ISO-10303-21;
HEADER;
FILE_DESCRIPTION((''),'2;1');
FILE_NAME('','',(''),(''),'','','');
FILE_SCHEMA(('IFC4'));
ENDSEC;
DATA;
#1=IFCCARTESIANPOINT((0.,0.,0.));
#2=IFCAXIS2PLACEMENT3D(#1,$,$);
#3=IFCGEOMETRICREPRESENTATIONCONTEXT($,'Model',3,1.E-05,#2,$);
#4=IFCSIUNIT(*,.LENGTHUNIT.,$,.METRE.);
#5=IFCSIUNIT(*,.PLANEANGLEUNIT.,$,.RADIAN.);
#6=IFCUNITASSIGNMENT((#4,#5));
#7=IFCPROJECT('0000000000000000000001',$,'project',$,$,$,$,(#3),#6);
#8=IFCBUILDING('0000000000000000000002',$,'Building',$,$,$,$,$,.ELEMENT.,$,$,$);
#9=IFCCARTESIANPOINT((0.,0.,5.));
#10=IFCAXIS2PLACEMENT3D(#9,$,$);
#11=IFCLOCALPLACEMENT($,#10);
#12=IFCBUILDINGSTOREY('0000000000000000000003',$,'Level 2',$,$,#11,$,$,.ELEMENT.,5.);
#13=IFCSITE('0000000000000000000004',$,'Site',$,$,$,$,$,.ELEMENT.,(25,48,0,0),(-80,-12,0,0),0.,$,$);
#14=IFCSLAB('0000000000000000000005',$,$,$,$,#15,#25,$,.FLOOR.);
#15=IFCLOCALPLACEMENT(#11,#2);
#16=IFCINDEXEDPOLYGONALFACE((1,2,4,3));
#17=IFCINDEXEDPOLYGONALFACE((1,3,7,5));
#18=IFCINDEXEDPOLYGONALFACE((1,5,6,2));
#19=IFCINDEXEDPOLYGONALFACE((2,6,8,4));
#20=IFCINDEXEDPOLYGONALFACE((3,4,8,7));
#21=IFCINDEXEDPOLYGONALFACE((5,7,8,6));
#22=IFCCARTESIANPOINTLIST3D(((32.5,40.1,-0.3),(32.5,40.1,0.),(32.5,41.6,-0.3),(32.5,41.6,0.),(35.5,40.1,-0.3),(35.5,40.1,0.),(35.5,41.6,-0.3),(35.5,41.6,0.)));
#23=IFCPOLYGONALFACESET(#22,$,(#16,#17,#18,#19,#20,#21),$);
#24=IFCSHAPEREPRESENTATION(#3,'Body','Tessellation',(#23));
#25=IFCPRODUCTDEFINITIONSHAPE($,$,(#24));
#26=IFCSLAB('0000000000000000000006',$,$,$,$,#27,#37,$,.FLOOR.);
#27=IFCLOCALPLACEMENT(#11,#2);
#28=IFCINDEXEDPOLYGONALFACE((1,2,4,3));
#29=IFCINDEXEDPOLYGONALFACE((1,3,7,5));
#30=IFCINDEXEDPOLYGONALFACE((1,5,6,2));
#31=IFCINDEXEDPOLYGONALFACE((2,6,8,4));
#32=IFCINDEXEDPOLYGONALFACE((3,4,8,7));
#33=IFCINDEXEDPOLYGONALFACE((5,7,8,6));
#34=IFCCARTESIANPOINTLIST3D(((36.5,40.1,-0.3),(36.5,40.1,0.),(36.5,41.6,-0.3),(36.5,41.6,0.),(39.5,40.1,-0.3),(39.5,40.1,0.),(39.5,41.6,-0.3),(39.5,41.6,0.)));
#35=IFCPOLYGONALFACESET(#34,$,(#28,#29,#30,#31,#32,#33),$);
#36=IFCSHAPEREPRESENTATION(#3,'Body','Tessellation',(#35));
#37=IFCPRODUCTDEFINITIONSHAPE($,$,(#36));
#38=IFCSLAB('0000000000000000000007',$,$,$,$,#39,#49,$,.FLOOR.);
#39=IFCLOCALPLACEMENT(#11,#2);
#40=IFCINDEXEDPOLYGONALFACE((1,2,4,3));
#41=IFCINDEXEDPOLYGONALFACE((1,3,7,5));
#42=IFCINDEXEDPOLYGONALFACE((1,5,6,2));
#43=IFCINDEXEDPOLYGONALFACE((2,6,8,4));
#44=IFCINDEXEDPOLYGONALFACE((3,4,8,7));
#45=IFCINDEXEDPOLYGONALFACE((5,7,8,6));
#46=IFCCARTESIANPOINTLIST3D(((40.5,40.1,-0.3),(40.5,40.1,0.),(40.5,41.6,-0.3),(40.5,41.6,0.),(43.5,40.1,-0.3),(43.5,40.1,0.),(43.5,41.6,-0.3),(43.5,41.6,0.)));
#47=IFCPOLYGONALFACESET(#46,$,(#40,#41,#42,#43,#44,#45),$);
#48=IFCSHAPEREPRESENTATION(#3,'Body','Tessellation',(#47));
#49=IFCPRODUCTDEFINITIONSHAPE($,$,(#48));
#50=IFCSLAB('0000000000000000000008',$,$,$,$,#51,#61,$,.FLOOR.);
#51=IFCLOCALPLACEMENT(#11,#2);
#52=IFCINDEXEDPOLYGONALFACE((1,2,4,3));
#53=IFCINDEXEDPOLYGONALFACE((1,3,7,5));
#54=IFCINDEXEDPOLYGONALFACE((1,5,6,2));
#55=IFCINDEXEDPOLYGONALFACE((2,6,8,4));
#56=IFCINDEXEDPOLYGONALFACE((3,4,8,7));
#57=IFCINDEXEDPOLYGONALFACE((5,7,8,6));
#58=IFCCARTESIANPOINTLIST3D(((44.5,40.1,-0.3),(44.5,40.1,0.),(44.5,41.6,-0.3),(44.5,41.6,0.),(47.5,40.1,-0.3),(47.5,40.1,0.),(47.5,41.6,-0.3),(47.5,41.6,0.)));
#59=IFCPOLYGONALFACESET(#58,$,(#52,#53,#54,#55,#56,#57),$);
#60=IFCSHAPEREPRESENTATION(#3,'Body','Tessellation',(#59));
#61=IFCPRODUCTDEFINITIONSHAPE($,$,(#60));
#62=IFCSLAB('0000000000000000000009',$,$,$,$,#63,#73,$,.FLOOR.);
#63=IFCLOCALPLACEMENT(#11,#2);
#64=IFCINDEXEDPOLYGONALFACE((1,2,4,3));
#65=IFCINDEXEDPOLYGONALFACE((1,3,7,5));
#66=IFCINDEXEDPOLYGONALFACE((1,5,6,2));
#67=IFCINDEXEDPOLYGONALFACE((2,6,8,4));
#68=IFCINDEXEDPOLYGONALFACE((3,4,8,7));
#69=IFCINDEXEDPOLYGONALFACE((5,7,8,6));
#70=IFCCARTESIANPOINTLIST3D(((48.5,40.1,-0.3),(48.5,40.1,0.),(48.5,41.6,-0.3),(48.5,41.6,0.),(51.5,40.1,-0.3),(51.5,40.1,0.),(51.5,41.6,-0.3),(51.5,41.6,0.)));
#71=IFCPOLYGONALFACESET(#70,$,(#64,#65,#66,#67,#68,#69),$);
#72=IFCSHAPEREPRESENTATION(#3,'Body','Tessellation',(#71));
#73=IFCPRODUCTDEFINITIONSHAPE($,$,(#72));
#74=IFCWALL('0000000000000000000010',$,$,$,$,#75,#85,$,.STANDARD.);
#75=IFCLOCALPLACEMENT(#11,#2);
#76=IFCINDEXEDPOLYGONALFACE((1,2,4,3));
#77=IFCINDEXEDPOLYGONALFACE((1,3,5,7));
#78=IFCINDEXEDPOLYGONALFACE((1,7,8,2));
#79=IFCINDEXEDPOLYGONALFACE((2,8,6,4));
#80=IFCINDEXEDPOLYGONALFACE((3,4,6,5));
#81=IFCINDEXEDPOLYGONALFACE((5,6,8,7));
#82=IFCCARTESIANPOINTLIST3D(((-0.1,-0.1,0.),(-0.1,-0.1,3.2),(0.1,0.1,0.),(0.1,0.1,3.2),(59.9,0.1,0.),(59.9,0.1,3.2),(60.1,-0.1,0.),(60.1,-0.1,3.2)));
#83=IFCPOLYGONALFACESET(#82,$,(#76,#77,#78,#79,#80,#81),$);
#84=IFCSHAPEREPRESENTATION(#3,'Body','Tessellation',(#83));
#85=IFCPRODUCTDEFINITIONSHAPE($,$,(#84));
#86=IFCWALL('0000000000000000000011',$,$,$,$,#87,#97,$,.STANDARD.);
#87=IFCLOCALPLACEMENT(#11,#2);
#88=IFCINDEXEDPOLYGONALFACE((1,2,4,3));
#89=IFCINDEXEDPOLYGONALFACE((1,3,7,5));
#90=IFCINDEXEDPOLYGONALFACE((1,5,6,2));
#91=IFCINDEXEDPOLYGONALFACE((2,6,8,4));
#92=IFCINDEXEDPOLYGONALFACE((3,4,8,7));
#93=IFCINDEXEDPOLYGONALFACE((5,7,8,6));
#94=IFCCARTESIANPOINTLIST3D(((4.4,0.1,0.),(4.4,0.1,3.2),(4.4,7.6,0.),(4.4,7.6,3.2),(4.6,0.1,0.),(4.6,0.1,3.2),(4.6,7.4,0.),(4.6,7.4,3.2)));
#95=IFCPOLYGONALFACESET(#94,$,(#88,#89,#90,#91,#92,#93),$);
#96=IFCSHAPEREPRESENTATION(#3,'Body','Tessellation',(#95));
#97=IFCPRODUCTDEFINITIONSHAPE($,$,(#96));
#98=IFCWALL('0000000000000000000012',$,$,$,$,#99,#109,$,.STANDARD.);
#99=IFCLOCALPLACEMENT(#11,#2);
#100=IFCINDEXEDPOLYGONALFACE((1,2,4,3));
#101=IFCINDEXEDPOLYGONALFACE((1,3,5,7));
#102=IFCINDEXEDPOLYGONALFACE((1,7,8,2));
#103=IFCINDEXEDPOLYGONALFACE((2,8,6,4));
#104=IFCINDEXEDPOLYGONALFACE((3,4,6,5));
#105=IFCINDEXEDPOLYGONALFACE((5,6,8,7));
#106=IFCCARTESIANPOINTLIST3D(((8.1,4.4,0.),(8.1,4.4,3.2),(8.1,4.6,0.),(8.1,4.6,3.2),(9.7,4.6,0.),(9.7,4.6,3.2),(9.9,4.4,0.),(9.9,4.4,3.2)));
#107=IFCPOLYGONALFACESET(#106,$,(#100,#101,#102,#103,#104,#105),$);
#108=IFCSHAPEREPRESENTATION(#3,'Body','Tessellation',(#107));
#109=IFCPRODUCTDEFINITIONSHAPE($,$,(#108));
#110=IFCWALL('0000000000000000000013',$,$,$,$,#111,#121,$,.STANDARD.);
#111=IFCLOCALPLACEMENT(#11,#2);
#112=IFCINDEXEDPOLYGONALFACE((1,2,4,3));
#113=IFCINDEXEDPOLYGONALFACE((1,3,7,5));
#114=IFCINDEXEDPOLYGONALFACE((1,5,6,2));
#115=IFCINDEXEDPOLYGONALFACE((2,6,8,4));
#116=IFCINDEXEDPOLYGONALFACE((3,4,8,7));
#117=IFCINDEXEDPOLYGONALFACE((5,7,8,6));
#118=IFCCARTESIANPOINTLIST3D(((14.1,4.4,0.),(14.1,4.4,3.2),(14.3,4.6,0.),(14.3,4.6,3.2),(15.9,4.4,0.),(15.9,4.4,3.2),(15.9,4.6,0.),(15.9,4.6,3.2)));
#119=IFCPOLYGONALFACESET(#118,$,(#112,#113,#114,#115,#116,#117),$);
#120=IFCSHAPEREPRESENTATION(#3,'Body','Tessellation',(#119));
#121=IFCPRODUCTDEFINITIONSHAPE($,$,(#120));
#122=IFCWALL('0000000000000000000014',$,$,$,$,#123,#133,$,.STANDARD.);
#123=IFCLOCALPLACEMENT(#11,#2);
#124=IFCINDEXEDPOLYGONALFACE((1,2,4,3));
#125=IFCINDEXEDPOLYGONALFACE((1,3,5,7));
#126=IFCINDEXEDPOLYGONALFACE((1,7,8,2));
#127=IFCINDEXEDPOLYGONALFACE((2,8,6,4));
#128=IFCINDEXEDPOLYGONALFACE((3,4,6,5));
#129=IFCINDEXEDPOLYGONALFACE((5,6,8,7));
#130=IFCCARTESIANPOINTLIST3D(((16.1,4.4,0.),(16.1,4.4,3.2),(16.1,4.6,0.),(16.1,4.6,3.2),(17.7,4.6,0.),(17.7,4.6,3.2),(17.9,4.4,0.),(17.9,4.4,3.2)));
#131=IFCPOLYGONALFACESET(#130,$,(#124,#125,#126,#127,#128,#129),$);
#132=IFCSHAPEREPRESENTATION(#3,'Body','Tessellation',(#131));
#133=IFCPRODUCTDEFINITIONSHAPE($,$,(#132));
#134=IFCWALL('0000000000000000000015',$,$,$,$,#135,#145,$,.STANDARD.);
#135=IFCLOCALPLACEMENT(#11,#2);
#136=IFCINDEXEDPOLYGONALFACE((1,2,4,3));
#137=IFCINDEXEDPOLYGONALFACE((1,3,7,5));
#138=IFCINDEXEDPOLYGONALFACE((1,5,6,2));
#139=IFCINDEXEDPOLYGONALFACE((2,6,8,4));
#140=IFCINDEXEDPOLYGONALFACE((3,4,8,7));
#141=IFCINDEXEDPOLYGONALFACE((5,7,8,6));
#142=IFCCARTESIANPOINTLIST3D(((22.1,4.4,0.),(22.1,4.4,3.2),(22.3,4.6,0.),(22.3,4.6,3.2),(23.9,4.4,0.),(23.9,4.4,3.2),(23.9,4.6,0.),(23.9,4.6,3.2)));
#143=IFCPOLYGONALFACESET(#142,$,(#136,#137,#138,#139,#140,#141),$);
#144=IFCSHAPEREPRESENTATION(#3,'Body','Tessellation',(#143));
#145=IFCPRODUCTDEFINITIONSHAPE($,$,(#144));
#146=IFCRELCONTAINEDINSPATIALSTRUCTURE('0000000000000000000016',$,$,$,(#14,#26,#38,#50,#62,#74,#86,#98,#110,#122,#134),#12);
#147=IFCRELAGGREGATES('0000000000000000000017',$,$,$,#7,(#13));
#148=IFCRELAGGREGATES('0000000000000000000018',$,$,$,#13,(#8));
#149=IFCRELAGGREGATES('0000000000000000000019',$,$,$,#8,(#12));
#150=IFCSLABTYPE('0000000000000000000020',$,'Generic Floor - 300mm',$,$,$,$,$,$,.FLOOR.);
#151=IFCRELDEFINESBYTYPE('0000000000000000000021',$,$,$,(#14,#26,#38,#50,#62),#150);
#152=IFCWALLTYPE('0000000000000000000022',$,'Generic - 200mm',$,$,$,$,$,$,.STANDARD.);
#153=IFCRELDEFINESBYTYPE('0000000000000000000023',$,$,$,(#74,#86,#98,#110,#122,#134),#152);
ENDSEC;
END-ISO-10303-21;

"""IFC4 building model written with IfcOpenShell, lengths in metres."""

from ifc_helpers import new_model, si_unit, frame, origin, place, context, project, spatial, polyline, outline, extrude, type_object, element, save


model = new_model("IFC4")

# Units and contexts
model_context = context("Model", 3, precision=1e-05, world=origin())
ifc_project = project(units=[si_unit("LENGTHUNIT", "METRE"), si_unit("PLANEANGLEUNIT", "RADIAN")], contexts=[model_context])

# Site, building, storey
site = spatial("IfcSite", under=ifc_project, Name="Site", CompositionType="ELEMENT", RefLatitude=(25, 48, 0, 0), RefLongitude=(-80, -12, 0, 0), RefElevation=0.0)
building = spatial("IfcBuilding", under=site, Name="Building", CompositionType="ELEMENT")
storey_placement = place(None, frame((0.0, 0.0, 5.0)))
storey = spatial("IfcBuildingStorey", under=building, at=storey_placement, Name="Level 2", CompositionType="ELEMENT", Elevation=5.0)

# Slabs
slab_type = type_object("IfcSlabType", Name="Generic Floor - 300mm", PredefinedType="FLOOR")
slab_1_placement = place(None, frame((0.0, 0.0, 5.0)))
element("IfcSlab", 1, at=slab_1_placement, inside=storey, type_object=slab_type, PredefinedType="FLOOR", context=model_context, shape_type="SweptSolid", body=[
    extrude(outline(polyline([(32.5, 40.1), (35.5, 40.1), (35.5, 41.6), (32.5, 41.6), (32.5, 40.1)])), origin(), (0.0, 0.0, -1.0), 0.3),
])
slab_2_placement = place(None, frame((0.0, 0.0, 5.0)))
element("IfcSlab", 2, at=slab_2_placement, inside=storey, type_object=slab_type, PredefinedType="FLOOR", context=model_context, shape_type="SweptSolid", body=[
    extrude(outline(polyline([(39.5, 40.1), (39.5, 41.6), (36.5, 41.6), (36.5, 40.1), (39.5, 40.1)])), origin(), (0.0, 0.0, -1.0), 0.3),
])
slab_3_placement = place(None, frame((0.0, 0.0, 5.0)))
element("IfcSlab", 3, at=slab_3_placement, inside=storey, type_object=slab_type, PredefinedType="FLOOR", context=model_context, shape_type="SweptSolid", body=[
    extrude(outline(polyline([(40.5, 40.1), (43.5, 40.1), (43.5, 41.6), (40.5, 41.6), (40.5, 40.1)])), origin(), (0.0, 0.0, -1.0), 0.3),
])
slab_4_placement = place(None, frame((0.0, 0.0, 5.0)))
element("IfcSlab", 4, at=slab_4_placement, inside=storey, type_object=slab_type, PredefinedType="FLOOR", context=model_context, shape_type="SweptSolid", body=[
    extrude(outline(polyline([(47.5, 40.1), (47.5, 41.6), (44.5, 41.6), (44.5, 40.1), (47.5, 40.1)])), origin(), (0.0, 0.0, -1.0), 0.3),
])
slab_5_placement = place(None, frame((0.0, 0.0, 5.0)))
element("IfcSlab", 5, at=slab_5_placement, inside=storey, type_object=slab_type, PredefinedType="FLOOR", context=model_context, shape_type="SweptSolid", body=[
    extrude(outline(polyline([(48.5, 40.1), (51.5, 40.1), (51.5, 41.6), (48.5, 41.6), (48.5, 40.1)])), origin(), (0.0, 0.0, -1.0), 0.3),
])

# Walls
wall_type = type_object("IfcWallType", Name="Generic - 200mm", PredefinedType="STANDARD")
wall_1_placement = place(None, frame((0.0, 0.0, 5.0), z_axis=(0.0, 0.0, 1.0), x_axis=(1.0, 0.0, 0.0)))
element("IfcWall", 6, at=wall_1_placement, inside=storey, type_object=wall_type, PredefinedType="STANDARD", context=model_context, shape_type="SweptSolid", body=[
    extrude(outline(polyline([(-0.1, -0.1), (60.1, -0.1), (59.9, 0.1), (0.1, 0.1), (-0.1, -0.1)])), origin(), (0.0, 0.0, 1.0), 3.2),
])
wall_2_placement = place(None, frame((4.5, 7.5, 5.0), z_axis=(0.0, 0.0, 1.0), x_axis=(0.0, -1.0, 0.0)))
element("IfcWall", 7, at=wall_2_placement, inside=storey, type_object=wall_type, PredefinedType="STANDARD", context=model_context, shape_type="SweptSolid", body=[
    extrude(outline(polyline([(-0.1, -0.1), (7.4, -0.1), (7.4, 0.1), (0.1, 0.1), (-0.1, -0.1)])), origin(), (0.0, 0.0, 1.0), 3.2),
])
wall_3_placement = place(None, frame((9.8, 4.5, 5.0), z_axis=(0.0, 0.0, 1.0), x_axis=(-1.0, 0.0, 0.0)))
element("IfcWall", 8, at=wall_3_placement, inside=storey, type_object=wall_type, PredefinedType="STANDARD", context=model_context, shape_type="SweptSolid", body=[
    extrude(outline(polyline([(0.1, -0.1), (1.7, -0.1), (1.7, 0.1), (-0.1, 0.1), (0.1, -0.1)])), origin(), (0.0, 0.0, 1.0), 3.2),
])
wall_4_placement = place(None, frame((14.2, 4.5, 5.0), z_axis=(0.0, 0.0, 1.0), x_axis=(1.0, 0.0, 0.0)))
element("IfcWall", 9, at=wall_4_placement, inside=storey, type_object=wall_type, PredefinedType="STANDARD", context=model_context, shape_type="SweptSolid", body=[
    extrude(outline(polyline([(-0.1, -0.1), (1.7, -0.1), (1.7, 0.1), (0.1, 0.1), (-0.1, -0.1)])), origin(), (0.0, 0.0, 1.0), 3.2),
])
wall_5_placement = place(None, frame((17.8, 4.5, 5.0), z_axis=(0.0, 0.0, 1.0), x_axis=(-1.0, 0.0, 0.0)))
element("IfcWall", 10, at=wall_5_placement, inside=storey, type_object=wall_type, PredefinedType="STANDARD", context=model_context, shape_type="SweptSolid", body=[
    extrude(outline(polyline([(0.1, -0.1), (1.7, -0.1), (1.7, 0.1), (-0.1, 0.1), (0.1, -0.1)])), origin(), (0.0, 0.0, 1.0), 3.2),
])
wall_6_placement = place(None, frame((22.2, 4.5, 5.0), z_axis=(0.0, 0.0, 1.0), x_axis=(1.0, 0.0, 0.0)))
element("IfcWall", 11, at=wall_6_placement, inside=storey, type_object=wall_type, PredefinedType="STANDARD", context=model_context, shape_type="SweptSolid", body=[
    extrude(outline(polyline([(-0.1, -0.1), (1.7, -0.1), (1.7, 0.1), (0.1, 0.1), (-0.1, -0.1)])), origin(), (0.0, 0.0, 1.0), 3.2),
])

save(model, "model.ifc")
